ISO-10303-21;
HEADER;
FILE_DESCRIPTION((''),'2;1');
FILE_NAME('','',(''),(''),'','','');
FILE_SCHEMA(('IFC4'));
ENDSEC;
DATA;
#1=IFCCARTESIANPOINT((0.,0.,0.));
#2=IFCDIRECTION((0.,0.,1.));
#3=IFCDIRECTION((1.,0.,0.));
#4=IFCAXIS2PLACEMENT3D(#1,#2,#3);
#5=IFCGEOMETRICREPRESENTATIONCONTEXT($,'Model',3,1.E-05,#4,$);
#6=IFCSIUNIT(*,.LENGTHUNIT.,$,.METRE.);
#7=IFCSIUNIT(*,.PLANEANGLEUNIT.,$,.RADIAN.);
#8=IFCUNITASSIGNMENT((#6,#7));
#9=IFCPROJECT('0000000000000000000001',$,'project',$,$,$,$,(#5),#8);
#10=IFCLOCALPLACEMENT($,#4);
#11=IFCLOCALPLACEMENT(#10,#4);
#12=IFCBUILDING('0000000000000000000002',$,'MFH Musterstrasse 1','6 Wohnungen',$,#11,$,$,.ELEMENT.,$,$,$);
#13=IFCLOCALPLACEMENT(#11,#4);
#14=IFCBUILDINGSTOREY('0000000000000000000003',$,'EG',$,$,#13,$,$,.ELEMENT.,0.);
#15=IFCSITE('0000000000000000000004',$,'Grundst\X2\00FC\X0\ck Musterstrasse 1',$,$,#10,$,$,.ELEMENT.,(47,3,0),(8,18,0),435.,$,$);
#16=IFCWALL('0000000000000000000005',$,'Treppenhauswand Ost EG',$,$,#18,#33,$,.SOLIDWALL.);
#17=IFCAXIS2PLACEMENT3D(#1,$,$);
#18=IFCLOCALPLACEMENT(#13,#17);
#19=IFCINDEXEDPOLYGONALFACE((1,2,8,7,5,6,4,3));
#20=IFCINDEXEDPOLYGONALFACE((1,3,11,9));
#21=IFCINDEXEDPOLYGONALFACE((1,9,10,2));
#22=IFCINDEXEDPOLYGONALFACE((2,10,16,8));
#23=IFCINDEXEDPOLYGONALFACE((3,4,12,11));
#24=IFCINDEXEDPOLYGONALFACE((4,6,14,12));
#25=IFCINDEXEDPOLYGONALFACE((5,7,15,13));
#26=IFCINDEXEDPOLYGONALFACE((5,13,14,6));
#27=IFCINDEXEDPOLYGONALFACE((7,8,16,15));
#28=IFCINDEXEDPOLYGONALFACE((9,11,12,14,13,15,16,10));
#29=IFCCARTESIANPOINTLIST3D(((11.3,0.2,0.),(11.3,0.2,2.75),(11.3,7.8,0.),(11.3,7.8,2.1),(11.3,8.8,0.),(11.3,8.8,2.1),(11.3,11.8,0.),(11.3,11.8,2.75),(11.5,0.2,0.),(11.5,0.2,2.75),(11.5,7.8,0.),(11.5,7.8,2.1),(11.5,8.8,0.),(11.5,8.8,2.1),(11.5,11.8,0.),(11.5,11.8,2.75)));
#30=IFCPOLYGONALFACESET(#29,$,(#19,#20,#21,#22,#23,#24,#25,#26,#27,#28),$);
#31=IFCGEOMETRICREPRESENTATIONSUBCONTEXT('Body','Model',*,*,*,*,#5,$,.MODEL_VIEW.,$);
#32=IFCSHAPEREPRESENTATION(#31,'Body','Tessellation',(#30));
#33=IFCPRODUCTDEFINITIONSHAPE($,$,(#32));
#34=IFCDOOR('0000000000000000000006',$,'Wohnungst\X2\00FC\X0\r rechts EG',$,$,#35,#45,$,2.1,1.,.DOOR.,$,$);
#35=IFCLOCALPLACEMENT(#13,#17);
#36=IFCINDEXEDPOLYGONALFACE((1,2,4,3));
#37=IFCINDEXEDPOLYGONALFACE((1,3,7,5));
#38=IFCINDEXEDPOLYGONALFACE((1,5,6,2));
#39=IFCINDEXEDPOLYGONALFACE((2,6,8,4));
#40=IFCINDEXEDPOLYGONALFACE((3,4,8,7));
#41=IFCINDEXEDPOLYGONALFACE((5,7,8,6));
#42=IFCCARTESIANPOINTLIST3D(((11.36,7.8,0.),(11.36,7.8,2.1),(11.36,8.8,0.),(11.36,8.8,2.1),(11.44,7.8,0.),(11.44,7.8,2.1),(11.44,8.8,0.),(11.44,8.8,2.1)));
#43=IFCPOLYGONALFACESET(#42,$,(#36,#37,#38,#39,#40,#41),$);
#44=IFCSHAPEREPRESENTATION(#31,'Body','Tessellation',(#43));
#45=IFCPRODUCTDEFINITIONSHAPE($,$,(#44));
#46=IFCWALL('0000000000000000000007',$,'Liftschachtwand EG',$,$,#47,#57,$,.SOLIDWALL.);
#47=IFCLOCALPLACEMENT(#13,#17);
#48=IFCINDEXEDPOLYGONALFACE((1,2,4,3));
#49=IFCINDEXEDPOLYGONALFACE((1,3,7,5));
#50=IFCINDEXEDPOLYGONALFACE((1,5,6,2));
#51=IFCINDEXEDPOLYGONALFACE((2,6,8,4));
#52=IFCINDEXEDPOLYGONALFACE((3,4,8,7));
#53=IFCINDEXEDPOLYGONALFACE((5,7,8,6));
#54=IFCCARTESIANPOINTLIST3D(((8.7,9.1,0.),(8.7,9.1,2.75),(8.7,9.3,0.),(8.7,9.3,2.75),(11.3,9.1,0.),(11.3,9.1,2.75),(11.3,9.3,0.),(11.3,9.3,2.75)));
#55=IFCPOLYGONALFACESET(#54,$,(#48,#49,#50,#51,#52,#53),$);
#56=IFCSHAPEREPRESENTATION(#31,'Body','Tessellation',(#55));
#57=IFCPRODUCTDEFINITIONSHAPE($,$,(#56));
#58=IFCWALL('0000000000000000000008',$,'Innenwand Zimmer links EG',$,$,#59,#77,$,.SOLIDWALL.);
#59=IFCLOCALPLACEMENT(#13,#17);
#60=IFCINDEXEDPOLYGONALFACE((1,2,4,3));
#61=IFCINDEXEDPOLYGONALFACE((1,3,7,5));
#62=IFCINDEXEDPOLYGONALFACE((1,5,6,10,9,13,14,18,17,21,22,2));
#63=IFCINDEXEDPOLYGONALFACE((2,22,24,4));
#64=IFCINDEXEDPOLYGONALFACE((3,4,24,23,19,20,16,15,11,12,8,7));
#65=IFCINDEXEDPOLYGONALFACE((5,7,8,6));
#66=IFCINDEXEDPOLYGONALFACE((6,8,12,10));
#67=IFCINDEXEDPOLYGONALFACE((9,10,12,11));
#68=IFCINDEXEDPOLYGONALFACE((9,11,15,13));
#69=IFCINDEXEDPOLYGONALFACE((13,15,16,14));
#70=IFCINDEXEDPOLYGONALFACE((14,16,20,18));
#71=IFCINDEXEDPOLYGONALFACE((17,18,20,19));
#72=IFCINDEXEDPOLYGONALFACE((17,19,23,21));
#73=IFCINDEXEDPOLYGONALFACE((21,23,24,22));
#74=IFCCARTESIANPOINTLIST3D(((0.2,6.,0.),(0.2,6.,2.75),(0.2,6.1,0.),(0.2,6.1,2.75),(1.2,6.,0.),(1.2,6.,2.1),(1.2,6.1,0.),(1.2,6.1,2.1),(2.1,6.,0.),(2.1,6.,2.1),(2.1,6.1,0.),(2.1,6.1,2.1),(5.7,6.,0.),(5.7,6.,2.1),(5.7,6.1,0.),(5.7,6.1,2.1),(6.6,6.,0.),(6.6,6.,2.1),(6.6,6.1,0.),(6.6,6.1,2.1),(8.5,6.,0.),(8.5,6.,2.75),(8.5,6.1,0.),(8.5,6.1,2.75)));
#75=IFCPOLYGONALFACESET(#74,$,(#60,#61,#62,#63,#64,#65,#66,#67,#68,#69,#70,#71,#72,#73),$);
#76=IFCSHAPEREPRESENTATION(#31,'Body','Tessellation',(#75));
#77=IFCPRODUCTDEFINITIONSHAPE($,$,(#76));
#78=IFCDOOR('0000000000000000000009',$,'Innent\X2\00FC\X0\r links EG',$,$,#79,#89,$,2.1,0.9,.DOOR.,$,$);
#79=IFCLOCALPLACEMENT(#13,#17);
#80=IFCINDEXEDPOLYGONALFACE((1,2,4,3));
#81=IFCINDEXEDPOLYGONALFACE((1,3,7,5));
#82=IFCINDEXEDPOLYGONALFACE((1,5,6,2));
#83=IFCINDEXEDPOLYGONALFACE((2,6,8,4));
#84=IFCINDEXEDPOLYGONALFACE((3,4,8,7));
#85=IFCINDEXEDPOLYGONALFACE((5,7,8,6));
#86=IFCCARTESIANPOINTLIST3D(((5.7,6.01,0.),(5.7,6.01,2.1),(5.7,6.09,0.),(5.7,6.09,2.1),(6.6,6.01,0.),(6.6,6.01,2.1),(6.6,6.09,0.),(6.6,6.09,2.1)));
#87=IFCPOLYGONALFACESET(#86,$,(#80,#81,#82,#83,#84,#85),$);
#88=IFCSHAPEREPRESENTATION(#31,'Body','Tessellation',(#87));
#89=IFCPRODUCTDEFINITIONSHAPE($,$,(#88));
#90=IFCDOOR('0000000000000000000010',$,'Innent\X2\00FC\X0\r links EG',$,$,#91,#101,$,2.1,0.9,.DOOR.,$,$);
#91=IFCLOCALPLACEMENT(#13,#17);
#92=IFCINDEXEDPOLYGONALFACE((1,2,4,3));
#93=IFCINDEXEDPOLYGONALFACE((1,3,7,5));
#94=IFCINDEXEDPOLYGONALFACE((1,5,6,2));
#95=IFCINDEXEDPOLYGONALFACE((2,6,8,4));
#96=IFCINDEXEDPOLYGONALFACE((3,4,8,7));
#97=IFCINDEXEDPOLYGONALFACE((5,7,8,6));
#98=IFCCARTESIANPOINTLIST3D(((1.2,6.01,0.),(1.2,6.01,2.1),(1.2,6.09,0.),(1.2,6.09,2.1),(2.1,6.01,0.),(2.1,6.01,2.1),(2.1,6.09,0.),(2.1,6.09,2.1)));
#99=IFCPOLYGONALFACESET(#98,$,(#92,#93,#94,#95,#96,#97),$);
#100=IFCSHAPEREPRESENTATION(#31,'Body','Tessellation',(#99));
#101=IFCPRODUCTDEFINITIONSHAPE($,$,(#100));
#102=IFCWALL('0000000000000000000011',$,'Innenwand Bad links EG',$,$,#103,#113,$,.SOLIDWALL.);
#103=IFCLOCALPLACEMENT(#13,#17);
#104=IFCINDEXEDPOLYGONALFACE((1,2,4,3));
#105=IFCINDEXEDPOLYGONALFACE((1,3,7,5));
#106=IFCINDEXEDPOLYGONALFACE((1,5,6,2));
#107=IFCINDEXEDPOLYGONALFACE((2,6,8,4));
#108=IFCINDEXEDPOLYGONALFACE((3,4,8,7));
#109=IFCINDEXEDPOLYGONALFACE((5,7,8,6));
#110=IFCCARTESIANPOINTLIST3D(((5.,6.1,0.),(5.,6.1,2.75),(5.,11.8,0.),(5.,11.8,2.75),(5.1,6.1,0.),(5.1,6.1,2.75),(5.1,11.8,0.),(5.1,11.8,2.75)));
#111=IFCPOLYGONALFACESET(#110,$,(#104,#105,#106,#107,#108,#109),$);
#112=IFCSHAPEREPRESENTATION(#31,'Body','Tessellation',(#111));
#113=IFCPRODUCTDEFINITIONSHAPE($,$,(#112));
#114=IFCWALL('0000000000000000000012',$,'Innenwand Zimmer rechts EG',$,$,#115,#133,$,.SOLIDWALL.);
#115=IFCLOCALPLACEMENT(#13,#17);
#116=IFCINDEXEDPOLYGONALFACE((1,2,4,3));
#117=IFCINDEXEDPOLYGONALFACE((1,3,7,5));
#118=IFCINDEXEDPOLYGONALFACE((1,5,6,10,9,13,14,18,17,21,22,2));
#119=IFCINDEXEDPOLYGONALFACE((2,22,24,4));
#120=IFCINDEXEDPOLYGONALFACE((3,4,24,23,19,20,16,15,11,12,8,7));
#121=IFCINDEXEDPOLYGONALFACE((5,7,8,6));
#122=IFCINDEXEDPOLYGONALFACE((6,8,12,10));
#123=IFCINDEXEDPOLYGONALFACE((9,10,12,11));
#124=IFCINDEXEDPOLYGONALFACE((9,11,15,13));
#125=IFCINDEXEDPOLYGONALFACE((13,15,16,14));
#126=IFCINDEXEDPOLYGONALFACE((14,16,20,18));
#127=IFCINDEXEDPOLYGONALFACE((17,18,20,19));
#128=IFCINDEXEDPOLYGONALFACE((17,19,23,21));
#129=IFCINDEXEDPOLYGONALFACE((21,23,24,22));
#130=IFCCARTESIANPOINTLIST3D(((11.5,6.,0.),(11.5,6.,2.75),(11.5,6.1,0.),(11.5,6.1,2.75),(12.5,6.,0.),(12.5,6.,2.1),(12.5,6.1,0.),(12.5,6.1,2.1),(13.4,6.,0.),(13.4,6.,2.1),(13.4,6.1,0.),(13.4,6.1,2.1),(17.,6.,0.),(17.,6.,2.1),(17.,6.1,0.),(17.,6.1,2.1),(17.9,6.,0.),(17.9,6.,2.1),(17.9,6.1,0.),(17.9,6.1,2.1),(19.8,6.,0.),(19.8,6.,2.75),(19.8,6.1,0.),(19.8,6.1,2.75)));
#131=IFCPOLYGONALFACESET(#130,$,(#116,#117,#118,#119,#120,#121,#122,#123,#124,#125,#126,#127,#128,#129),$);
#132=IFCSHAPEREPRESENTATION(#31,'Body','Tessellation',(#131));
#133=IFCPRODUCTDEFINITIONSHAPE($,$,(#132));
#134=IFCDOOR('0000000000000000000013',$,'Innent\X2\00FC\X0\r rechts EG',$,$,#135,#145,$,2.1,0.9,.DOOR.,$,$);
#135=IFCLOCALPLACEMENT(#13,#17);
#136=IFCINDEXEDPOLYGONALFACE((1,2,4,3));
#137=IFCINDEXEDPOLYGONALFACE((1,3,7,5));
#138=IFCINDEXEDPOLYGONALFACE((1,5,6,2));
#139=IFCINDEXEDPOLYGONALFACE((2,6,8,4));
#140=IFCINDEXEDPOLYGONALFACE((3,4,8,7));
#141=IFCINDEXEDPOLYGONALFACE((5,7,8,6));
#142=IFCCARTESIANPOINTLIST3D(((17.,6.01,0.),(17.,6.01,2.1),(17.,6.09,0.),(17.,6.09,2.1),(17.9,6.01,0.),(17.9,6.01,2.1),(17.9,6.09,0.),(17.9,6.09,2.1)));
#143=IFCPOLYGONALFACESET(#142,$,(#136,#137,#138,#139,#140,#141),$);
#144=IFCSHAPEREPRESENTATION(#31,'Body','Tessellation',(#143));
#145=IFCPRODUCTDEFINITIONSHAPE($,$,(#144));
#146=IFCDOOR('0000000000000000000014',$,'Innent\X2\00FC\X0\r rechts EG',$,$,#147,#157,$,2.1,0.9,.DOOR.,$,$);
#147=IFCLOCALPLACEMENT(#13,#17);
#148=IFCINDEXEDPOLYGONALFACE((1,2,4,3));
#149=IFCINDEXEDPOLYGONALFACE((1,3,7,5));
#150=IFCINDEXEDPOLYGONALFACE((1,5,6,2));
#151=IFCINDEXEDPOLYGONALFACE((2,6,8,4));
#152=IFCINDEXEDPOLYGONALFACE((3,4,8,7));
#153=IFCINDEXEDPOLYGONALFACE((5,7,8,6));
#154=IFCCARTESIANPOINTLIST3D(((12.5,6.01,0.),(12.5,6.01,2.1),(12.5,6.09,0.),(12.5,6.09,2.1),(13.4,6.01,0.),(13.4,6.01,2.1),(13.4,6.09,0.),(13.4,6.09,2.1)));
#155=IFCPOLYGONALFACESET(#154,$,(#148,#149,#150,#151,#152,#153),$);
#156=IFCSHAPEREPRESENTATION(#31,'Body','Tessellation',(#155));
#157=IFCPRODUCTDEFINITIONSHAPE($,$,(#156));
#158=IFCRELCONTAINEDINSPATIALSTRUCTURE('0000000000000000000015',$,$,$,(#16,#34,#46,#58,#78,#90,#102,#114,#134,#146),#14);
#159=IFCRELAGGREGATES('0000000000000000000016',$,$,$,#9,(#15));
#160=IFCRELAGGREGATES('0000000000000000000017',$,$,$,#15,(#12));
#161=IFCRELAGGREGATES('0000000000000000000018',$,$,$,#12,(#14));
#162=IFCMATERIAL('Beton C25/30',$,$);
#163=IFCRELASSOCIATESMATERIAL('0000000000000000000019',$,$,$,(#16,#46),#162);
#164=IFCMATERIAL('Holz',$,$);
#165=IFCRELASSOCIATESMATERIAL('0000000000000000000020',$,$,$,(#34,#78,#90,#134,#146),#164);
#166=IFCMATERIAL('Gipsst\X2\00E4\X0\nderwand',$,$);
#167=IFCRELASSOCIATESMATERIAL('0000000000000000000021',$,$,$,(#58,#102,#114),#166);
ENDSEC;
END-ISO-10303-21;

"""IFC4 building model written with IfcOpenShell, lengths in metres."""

from ifc_helpers import new_model, si_unit, frame, frame_2d, origin_with_axes, place, context, subcontext, project, spatial, rectangle, extrude, material, element, fill, save


model = new_model("IFC4")

# Units and contexts
model_context = context("Model", 3, precision=1e-05, world=origin_with_axes())
body_context = subcontext(model_context, "Body", "Model", "MODEL_VIEW")
ifc_project = project(units=[si_unit("LENGTHUNIT", "METRE"), si_unit("PLANEANGLEUNIT", "RADIAN")], contexts=[model_context])

# Site, building, storey
site_placement = place(None, origin_with_axes())
site = spatial("IfcSite", under=ifc_project, at=site_placement, Name="Grundstück Musterstrasse 1", CompositionType="ELEMENT", RefLatitude=(47, 3, 0), RefLongitude=(8, 18, 0), RefElevation=435.0)
building_placement = place(site_placement, origin_with_axes())
building = spatial("IfcBuilding", under=site, at=building_placement, Name="MFH Musterstrasse 1", Description="6 Wohnungen", CompositionType="ELEMENT")
storey_placement = place(building_placement, origin_with_axes())
storey = spatial("IfcBuildingStorey", under=building, at=storey_placement, Name="EG", CompositionType="ELEMENT", Elevation=0.0)

# Wall, openings, door
ifc_material_1 = material(Name="Beton C25/30")
wall_1_placement = place(storey_placement, origin_with_axes())
wall_1 = element("IfcWall", 1, at=wall_1_placement, inside=storey, material=ifc_material_1, Name="Treppenhauswand Ost EG", PredefinedType="SOLIDWALL", context=body_context, shape_type="SweptSolid", body=[
    extrude(rectangle(XDim=0.2, YDim=11.6, at=frame_2d((0.1, 5.8), x_axis=(1.0, 0.0))), frame((11.3, 0.2, 0.0), z_axis=(0.0, 0.0, 1.0), x_axis=(1.0, 0.0, 0.0)), (0.0, 0.0, 1.0), 2.75),
])
opening_1_placement = place(storey_placement, origin_with_axes())
element("IfcOpeningElement", 2, at=opening_1_placement, cuts=wall_1, PredefinedType="OPENING", context=body_context, shape_type="SweptSolid", body=[
    extrude(rectangle(XDim=0.3, YDim=1.0, at=frame_2d((0.15, 0.5), x_axis=(1.0, 0.0))), frame((11.25, 7.8, 0.0), z_axis=(0.0, 0.0, 1.0), x_axis=(1.0, 0.0, 0.0)), (0.0, 0.0, 1.0), 2.1),
])
opening_2_placement = place(storey_placement, origin_with_axes())
opening_2 = element("IfcOpeningElement", 3, at=opening_2_placement, cuts=wall_1, PredefinedType="OPENING", context=body_context, shape_type="SweptSolid", body=[
    extrude(rectangle(XDim=0.22, YDim=1.0, at=frame_2d((0.11, 0.5), x_axis=(1.0, 0.0))), frame((11.29, 7.8, 0.0), z_axis=(0.0, 0.0, 1.0), x_axis=(1.0, 0.0, 0.0)), (0.0, 0.0, 1.0), 2.1),
])
ifc_material_2 = material(Name="Holz")
door_1_placement = place(storey_placement, origin_with_axes())
door_1 = element("IfcDoor", 4, at=door_1_placement, inside=storey, material=ifc_material_2, Name="Wohnungstür rechts EG", OverallHeight=2.1, OverallWidth=1.0, PredefinedType="DOOR", context=body_context, shape_type="SweptSolid", body=[
    extrude(rectangle(XDim=0.08, YDim=1.0, at=frame_2d((0.04, 0.5), x_axis=(1.0, 0.0))), frame((11.36, 7.8, 0.0), z_axis=(0.0, 0.0, 1.0), x_axis=(1.0, 0.0, 0.0)), (0.0, 0.0, 1.0), 2.1),
])
fill(opening_2, door_1)

# Wall
wall_2_placement = place(storey_placement, origin_with_axes())
element("IfcWall", 5, at=wall_2_placement, inside=storey, material=ifc_material_1, Name="Liftschachtwand EG", PredefinedType="SOLIDWALL", context=body_context, shape_type="SweptSolid", body=[
    extrude(rectangle(XDim=2.6, YDim=0.2, at=frame_2d((1.3, 0.1), x_axis=(1.0, 0.0))), frame((8.7, 9.1, 0.0), z_axis=(0.0, 0.0, 1.0), x_axis=(1.0, 0.0, 0.0)), (0.0, 0.0, 1.0), 2.75),
])

# Wall, openings, doors
ifc_material_3 = material(Name="Gipsständerwand")
wall_3_placement = place(storey_placement, origin_with_axes())
wall_3 = element("IfcWall", 6, at=wall_3_placement, inside=storey, material=ifc_material_3, Name="Innenwand Zimmer links EG", PredefinedType="SOLIDWALL", context=body_context, shape_type="SweptSolid", body=[
    extrude(rectangle(XDim=8.3, YDim=0.1, at=frame_2d((4.15, 0.05), x_axis=(1.0, 0.0))), frame((0.2, 6.0, 0.0), z_axis=(0.0, 0.0, 1.0), x_axis=(1.0, 0.0, 0.0)), (0.0, 0.0, 1.0), 2.75),
])
opening_3_placement = place(storey_placement, origin_with_axes())
element("IfcOpeningElement", 7, at=opening_3_placement, cuts=wall_3, PredefinedType="OPENING", context=body_context, shape_type="SweptSolid", body=[
    extrude(rectangle(XDim=0.9, YDim=0.2, at=frame_2d((0.45, 0.1), x_axis=(1.0, 0.0))), frame((5.7, 5.95, 0.0), z_axis=(0.0, 0.0, 1.0), x_axis=(1.0, 0.0, 0.0)), (0.0, 0.0, 1.0), 2.1),
])
opening_4_placement = place(storey_placement, origin_with_axes())
element("IfcOpeningElement", 8, at=opening_4_placement, cuts=wall_3, PredefinedType="OPENING", context=body_context, shape_type="SweptSolid", body=[
    extrude(rectangle(XDim=0.9, YDim=0.2, at=frame_2d((0.45, 0.1), x_axis=(1.0, 0.0))), frame((1.2, 5.95, 0.0), z_axis=(0.0, 0.0, 1.0), x_axis=(1.0, 0.0, 0.0)), (0.0, 0.0, 1.0), 2.1),
])
opening_5_placement = place(storey_placement, origin_with_axes())
opening_5 = element("IfcOpeningElement", 9, at=opening_5_placement, cuts=wall_3, PredefinedType="OPENING", context=body_context, shape_type="SweptSolid", body=[
    extrude(rectangle(XDim=0.9, YDim=0.12, at=frame_2d((0.45, 0.06), x_axis=(1.0, 0.0))), frame((5.7, 5.99, 0.0), z_axis=(0.0, 0.0, 1.0), x_axis=(1.0, 0.0, 0.0)), (0.0, 0.0, 1.0), 2.1),
])
opening_6_placement = place(storey_placement, origin_with_axes())
opening_6 = element("IfcOpeningElement", 10, at=opening_6_placement, cuts=wall_3, PredefinedType="OPENING", context=body_context, shape_type="SweptSolid", body=[
    extrude(rectangle(XDim=0.9, YDim=0.12, at=frame_2d((0.45, 0.06), x_axis=(1.0, 0.0))), frame((1.2, 5.99, 0.0), z_axis=(0.0, 0.0, 1.0), x_axis=(1.0, 0.0, 0.0)), (0.0, 0.0, 1.0), 2.1),
])
door_2_placement = place(storey_placement, origin_with_axes())
door_2 = element("IfcDoor", 11, at=door_2_placement, inside=storey, material=ifc_material_2, Name="Innentür links EG", OverallHeight=2.1, OverallWidth=0.9, PredefinedType="DOOR", context=body_context, shape_type="SweptSolid", body=[
    extrude(rectangle(XDim=0.9, YDim=0.08, at=frame_2d((0.45, 0.04), x_axis=(1.0, 0.0))), frame((5.7, 6.01, 0.0), z_axis=(0.0, 0.0, 1.0), x_axis=(1.0, 0.0, 0.0)), (0.0, 0.0, 1.0), 2.1),
])
fill(opening_5, door_2)
door_3_placement = place(storey_placement, origin_with_axes())
door_3 = element("IfcDoor", 12, at=door_3_placement, inside=storey, material=ifc_material_2, Name="Innentür links EG", OverallHeight=2.1, OverallWidth=0.9, PredefinedType="DOOR", context=body_context, shape_type="SweptSolid", body=[
    extrude(rectangle(XDim=0.9, YDim=0.08, at=frame_2d((0.45, 0.04), x_axis=(1.0, 0.0))), frame((1.2, 6.01, 0.0), z_axis=(0.0, 0.0, 1.0), x_axis=(1.0, 0.0, 0.0)), (0.0, 0.0, 1.0), 2.1),
])
fill(opening_6, door_3)

# Wall
wall_4_placement = place(storey_placement, origin_with_axes())
element("IfcWall", 13, at=wall_4_placement, inside=storey, material=ifc_material_3, Name="Innenwand Bad links EG", PredefinedType="SOLIDWALL", context=body_context, shape_type="SweptSolid", body=[
    extrude(rectangle(XDim=0.1, YDim=5.7, at=frame_2d((0.05, 2.85), x_axis=(1.0, 0.0))), frame((5.0, 6.1, 0.0), z_axis=(0.0, 0.0, 1.0), x_axis=(1.0, 0.0, 0.0)), (0.0, 0.0, 1.0), 2.75),
])

# Wall, openings, doors
wall_5_placement = place(storey_placement, origin_with_axes())
wall_5 = element("IfcWall", 14, at=wall_5_placement, inside=storey, material=ifc_material_3, Name="Innenwand Zimmer rechts EG", PredefinedType="SOLIDWALL", context=body_context, shape_type="SweptSolid", body=[
    extrude(rectangle(XDim=8.3, YDim=0.1, at=frame_2d((4.15, 0.05), x_axis=(1.0, 0.0))), frame((11.5, 6.0, 0.0), z_axis=(0.0, 0.0, 1.0), x_axis=(1.0, 0.0, 0.0)), (0.0, 0.0, 1.0), 2.75),
])
opening_7_placement = place(storey_placement, origin_with_axes())
element("IfcOpeningElement", 15, at=opening_7_placement, cuts=wall_5, PredefinedType="OPENING", context=body_context, shape_type="SweptSolid", body=[
    extrude(rectangle(XDim=0.9, YDim=0.2, at=frame_2d((0.45, 0.1), x_axis=(1.0, 0.0))), frame((17.0, 5.95, 0.0), z_axis=(0.0, 0.0, 1.0), x_axis=(1.0, 0.0, 0.0)), (0.0, 0.0, 1.0), 2.1),
])
opening_8_placement = place(storey_placement, origin_with_axes())
element("IfcOpeningElement", 16, at=opening_8_placement, cuts=wall_5, PredefinedType="OPENING", context=body_context, shape_type="SweptSolid", body=[
    extrude(rectangle(XDim=0.9, YDim=0.2, at=frame_2d((0.45, 0.1), x_axis=(1.0, 0.0))), frame((12.5, 5.95, 0.0), z_axis=(0.0, 0.0, 1.0), x_axis=(1.0, 0.0, 0.0)), (0.0, 0.0, 1.0), 2.1),
])
opening_9_placement = place(storey_placement, origin_with_axes())
opening_9 = element("IfcOpeningElement", 17, at=opening_9_placement, cuts=wall_5, PredefinedType="OPENING", context=body_context, shape_type="SweptSolid", body=[
    extrude(rectangle(XDim=0.9, YDim=0.12, at=frame_2d((0.45, 0.06), x_axis=(1.0, 0.0))), frame((17.0, 5.99, 0.0), z_axis=(0.0, 0.0, 1.0), x_axis=(1.0, 0.0, 0.0)), (0.0, 0.0, 1.0), 2.1),
])
opening_10_placement = place(storey_placement, origin_with_axes())
opening_10 = element("IfcOpeningElement", 18, at=opening_10_placement, cuts=wall_5, PredefinedType="OPENING", context=body_context, shape_type="SweptSolid", body=[
    extrude(rectangle(XDim=0.9, YDim=0.12, at=frame_2d((0.45, 0.06), x_axis=(1.0, 0.0))), frame((12.5, 5.99, 0.0), z_axis=(0.0, 0.0, 1.0), x_axis=(1.0, 0.0, 0.0)), (0.0, 0.0, 1.0), 2.1),
])
door_4_placement = place(storey_placement, origin_with_axes())
door_4 = element("IfcDoor", 19, at=door_4_placement, inside=storey, material=ifc_material_2, Name="Innentür rechts EG", OverallHeight=2.1, OverallWidth=0.9, PredefinedType="DOOR", context=body_context, shape_type="SweptSolid", body=[
    extrude(rectangle(XDim=0.9, YDim=0.08, at=frame_2d((0.45, 0.04), x_axis=(1.0, 0.0))), frame((17.0, 6.01, 0.0), z_axis=(0.0, 0.0, 1.0), x_axis=(1.0, 0.0, 0.0)), (0.0, 0.0, 1.0), 2.1),
])
fill(opening_9, door_4)
door_5_placement = place(storey_placement, origin_with_axes())
door_5 = element("IfcDoor", 20, at=door_5_placement, inside=storey, material=ifc_material_2, Name="Innentür rechts EG", OverallHeight=2.1, OverallWidth=0.9, PredefinedType="DOOR", context=body_context, shape_type="SweptSolid", body=[
    extrude(rectangle(XDim=0.9, YDim=0.08, at=frame_2d((0.45, 0.04), x_axis=(1.0, 0.0))), frame((12.5, 6.01, 0.0), z_axis=(0.0, 0.0, 1.0), x_axis=(1.0, 0.0, 0.0)), (0.0, 0.0, 1.0), 2.1),
])
fill(opening_10, door_5)

save(model, "model.ifc")
